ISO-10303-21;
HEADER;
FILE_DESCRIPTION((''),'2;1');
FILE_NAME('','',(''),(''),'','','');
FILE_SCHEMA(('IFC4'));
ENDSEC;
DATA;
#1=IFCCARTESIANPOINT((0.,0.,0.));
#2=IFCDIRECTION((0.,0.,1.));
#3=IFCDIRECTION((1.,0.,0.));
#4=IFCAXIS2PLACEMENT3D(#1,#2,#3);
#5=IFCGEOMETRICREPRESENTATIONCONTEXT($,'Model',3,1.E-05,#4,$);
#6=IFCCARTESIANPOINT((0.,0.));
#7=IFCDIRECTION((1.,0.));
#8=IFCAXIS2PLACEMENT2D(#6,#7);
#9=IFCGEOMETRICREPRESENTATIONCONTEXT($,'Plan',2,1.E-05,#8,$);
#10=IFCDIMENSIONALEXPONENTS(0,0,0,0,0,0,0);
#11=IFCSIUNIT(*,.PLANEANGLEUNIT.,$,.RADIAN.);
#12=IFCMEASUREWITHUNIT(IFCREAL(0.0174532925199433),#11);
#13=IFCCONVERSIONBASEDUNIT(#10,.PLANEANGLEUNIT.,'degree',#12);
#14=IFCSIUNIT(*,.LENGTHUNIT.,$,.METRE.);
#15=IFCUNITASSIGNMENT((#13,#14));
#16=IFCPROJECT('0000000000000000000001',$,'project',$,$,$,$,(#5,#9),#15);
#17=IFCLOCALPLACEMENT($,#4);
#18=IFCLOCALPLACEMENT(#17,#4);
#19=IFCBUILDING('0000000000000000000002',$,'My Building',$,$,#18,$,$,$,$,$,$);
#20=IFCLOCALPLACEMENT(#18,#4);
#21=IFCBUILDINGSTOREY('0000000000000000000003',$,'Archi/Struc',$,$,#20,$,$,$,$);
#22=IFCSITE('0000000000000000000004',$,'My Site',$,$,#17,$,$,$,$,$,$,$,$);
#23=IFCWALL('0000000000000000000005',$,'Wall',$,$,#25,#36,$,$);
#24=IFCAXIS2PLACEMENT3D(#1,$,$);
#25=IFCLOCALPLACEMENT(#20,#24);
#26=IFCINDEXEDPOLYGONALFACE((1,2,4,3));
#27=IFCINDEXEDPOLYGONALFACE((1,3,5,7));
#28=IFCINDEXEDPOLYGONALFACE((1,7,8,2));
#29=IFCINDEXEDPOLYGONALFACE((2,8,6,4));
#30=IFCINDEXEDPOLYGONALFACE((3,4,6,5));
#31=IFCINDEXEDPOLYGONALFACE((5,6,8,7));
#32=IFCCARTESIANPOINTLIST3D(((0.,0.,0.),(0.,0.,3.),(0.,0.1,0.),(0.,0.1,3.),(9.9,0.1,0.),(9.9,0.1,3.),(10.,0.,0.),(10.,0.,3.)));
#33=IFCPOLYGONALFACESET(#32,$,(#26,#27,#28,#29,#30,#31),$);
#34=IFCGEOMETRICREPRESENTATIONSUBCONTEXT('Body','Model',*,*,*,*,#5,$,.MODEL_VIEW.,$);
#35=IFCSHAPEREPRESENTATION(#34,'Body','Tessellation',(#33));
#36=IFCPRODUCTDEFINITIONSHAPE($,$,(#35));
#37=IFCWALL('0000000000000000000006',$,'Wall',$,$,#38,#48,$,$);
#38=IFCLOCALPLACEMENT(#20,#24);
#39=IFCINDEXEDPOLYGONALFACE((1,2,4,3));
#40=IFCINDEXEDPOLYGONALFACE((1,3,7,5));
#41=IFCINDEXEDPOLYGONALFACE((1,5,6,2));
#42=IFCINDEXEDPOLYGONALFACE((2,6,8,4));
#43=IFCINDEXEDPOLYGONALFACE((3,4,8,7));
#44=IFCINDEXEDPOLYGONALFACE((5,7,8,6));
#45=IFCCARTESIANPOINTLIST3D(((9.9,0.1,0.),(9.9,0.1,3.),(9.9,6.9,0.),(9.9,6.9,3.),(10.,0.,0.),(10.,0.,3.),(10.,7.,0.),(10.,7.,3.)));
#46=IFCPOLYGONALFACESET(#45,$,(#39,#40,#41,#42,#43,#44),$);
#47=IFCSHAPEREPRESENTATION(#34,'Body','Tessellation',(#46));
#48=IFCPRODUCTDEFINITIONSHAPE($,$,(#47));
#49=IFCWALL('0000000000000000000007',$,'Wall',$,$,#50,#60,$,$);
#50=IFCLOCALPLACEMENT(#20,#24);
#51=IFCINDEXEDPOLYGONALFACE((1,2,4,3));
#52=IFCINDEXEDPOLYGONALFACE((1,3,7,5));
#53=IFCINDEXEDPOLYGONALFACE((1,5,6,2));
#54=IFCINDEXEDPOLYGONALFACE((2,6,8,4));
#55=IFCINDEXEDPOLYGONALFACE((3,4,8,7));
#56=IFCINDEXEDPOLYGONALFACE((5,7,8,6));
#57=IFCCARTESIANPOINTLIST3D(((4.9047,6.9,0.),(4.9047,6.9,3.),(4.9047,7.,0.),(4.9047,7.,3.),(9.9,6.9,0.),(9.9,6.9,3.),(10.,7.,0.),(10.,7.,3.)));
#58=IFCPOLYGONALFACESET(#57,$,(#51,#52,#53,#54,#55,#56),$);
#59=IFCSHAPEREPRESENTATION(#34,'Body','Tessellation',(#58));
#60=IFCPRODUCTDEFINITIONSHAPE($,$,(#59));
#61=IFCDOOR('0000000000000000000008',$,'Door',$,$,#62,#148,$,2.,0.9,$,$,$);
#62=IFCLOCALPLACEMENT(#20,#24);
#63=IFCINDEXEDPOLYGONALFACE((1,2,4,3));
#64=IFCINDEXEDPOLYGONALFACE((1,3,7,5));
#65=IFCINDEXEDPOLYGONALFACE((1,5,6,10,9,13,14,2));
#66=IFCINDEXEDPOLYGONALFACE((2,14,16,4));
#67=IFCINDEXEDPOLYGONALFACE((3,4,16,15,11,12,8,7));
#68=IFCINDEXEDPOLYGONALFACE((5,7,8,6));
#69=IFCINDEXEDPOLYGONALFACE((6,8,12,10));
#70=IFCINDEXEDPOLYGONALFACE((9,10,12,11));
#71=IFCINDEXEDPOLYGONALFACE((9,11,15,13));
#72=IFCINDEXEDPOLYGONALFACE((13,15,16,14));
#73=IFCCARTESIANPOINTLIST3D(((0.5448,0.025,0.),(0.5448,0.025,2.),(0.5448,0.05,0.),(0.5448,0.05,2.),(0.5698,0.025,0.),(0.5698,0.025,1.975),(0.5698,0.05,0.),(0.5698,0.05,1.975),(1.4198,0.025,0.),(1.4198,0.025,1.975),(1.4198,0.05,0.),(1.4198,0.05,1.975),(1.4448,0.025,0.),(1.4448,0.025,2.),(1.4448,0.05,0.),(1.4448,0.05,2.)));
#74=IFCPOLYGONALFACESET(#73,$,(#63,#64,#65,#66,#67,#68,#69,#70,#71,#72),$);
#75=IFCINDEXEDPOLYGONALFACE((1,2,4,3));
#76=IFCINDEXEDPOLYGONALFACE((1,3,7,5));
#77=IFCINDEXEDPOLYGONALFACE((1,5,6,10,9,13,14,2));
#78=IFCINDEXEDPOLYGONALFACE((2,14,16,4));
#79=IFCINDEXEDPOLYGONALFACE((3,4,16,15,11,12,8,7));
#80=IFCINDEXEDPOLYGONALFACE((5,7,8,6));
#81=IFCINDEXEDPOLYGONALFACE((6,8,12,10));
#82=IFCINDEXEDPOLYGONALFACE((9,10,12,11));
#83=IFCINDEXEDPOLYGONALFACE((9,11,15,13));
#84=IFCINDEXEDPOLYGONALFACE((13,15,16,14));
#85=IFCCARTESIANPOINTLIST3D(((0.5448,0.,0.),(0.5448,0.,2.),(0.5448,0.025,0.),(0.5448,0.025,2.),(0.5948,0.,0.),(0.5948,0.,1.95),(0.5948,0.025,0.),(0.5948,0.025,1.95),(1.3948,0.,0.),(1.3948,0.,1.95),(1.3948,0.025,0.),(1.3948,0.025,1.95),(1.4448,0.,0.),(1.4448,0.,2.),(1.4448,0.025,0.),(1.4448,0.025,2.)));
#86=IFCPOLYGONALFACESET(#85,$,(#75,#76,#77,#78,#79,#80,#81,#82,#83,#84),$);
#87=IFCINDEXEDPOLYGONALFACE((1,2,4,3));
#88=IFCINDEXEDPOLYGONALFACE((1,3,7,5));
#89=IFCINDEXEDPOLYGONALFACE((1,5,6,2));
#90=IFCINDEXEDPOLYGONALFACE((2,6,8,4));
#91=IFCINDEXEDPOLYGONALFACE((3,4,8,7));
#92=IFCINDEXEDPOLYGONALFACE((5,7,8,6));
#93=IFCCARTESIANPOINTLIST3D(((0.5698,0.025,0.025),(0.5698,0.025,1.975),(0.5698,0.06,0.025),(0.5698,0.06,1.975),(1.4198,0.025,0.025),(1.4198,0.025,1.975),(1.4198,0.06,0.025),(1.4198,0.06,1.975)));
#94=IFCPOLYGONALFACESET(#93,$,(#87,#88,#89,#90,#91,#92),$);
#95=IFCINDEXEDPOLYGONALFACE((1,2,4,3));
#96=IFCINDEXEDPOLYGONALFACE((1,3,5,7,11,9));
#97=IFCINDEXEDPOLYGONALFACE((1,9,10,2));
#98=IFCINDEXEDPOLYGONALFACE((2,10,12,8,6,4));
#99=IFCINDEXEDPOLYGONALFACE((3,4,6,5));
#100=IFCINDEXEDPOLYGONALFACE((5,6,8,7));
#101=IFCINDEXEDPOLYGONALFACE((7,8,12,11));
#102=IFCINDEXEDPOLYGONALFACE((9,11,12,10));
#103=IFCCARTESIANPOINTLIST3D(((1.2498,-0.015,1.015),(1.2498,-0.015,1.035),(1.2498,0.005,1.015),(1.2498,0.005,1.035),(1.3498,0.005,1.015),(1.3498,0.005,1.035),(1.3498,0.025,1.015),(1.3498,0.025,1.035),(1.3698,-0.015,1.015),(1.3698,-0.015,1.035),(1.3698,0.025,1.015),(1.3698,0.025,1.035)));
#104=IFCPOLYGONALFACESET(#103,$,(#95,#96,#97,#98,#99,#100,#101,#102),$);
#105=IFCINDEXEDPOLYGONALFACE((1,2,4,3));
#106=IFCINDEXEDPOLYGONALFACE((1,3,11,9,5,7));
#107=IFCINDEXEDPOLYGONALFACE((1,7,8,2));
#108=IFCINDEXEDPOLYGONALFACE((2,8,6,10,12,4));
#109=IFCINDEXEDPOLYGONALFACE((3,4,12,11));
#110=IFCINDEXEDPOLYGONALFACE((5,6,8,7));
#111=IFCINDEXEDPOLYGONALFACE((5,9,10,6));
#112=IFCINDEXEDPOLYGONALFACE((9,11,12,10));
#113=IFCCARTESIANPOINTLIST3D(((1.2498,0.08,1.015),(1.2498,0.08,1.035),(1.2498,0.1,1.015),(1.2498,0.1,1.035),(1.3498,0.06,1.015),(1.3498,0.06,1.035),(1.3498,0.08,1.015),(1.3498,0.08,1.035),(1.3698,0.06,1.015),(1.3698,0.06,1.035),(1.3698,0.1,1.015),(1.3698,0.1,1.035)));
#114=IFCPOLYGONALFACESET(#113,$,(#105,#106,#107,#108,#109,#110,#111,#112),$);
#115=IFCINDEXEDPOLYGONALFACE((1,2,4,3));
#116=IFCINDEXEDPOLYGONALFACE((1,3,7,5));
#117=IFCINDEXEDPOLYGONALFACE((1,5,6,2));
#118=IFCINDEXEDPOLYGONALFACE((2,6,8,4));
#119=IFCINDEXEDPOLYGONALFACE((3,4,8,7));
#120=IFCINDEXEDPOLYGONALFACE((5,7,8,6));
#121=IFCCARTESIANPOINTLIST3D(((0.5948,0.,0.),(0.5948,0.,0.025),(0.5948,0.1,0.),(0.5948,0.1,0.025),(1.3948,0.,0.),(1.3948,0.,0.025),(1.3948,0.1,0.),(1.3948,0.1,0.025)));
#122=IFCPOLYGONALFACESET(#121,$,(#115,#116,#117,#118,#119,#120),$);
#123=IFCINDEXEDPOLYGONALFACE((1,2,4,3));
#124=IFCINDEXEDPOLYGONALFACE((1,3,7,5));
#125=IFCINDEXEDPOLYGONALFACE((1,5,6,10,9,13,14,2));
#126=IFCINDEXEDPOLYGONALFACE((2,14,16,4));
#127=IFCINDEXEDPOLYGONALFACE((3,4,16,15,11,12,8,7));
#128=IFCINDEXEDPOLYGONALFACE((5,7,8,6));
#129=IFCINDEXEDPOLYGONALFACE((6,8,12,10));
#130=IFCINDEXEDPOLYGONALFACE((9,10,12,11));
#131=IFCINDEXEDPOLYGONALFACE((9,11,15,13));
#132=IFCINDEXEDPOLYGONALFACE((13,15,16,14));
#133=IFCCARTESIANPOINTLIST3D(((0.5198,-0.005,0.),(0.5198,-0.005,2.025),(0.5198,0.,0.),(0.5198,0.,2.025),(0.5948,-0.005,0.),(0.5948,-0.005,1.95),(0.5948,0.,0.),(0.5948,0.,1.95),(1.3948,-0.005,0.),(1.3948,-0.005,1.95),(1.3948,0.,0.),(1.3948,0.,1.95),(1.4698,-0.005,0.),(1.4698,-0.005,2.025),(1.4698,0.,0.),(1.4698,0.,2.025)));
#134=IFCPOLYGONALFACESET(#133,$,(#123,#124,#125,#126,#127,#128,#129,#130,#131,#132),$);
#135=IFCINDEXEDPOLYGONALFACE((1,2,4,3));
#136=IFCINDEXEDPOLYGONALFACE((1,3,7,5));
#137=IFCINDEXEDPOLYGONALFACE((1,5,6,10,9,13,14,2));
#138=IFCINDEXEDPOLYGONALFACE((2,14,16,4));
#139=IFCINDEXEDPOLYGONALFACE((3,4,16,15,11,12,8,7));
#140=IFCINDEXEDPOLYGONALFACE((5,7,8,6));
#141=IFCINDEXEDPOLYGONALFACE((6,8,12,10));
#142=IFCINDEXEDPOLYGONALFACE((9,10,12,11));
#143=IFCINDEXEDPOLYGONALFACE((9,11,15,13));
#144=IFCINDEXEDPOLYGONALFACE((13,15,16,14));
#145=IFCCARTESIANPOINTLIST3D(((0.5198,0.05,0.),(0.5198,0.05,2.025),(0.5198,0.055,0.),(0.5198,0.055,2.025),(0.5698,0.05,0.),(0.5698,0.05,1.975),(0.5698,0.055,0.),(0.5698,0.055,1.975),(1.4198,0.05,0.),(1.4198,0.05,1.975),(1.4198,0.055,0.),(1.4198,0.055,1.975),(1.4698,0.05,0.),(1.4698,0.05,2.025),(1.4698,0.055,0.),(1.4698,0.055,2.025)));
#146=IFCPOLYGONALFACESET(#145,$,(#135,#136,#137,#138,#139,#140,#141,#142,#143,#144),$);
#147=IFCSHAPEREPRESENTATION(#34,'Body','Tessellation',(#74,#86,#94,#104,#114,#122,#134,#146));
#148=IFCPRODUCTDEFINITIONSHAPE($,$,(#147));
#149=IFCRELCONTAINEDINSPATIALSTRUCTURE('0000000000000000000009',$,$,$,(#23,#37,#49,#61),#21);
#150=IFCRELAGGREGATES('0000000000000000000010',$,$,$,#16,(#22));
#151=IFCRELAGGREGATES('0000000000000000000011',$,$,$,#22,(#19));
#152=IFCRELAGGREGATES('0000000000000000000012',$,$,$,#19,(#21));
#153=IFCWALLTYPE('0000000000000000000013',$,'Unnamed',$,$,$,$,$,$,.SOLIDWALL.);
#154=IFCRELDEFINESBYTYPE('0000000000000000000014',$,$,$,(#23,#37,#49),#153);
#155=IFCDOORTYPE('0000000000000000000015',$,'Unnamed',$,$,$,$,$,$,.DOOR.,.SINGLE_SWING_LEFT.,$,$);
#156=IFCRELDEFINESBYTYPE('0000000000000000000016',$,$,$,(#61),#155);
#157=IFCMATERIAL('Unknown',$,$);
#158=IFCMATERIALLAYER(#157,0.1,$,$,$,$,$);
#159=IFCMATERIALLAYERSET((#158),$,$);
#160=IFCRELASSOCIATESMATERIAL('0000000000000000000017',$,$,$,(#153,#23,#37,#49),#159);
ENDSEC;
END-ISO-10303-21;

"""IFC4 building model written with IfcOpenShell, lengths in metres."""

from ifc_helpers import new_model, entity, si_unit, converted_unit, frame, origin_with_axes, origin_2d_with_axis, place, context, subcontext, project, spatial, line, indexed_curve, outline, extrude, shape, source, transform, mapped, material, layer, layer_set, layer_usage, type_object, type_shapes, element, save


model = new_model("IFC4")

# Units and contexts
model_context = context("Model", 3, precision=1e-05, world=origin_with_axes())
plan_context = context("Plan", 2, precision=1e-05, world=origin_2d_with_axis())
body_context_1 = subcontext(model_context, "Body", "Model", "MODEL_VIEW")
body_context_2 = subcontext(plan_context, "Body", "Plan", "PLAN_VIEW")
ifc_project = project(units=[converted_unit("PLANEANGLEUNIT", "degree", entity("IfcReal", 0.0174532925199433), si_unit("PLANEANGLEUNIT", "RADIAN"), dimensions=[0, 0, 0, 0, 0, 0, 0]), si_unit("LENGTHUNIT", "METRE")], contexts=[model_context, plan_context])

# Site, building, storey
site_placement = place(None, origin_with_axes())
site = spatial("IfcSite", under=ifc_project, at=site_placement, Name="My Site")
building_placement = place(site_placement, origin_with_axes())
building = spatial("IfcBuilding", under=site, at=building_placement, Name="My Building")
storey_placement = place(building_placement, origin_with_axes())
storey = spatial("IfcBuildingStorey", under=building, at=storey_placement, Name="Archi/Struc")

# Shared definitions
ifc_material = material(Name="Unknown")

# Shared definitions
ifc_layer_1 = layer(ifc_material, 0.1)
ifc_layer_set_1 = layer_set([ifc_layer_1])
wall_type = type_object("IfcWallType", Name="Unnamed", PredefinedType="SOLIDWALL", material=ifc_layer_set_1)

# Shared definitions
door_type = type_object("IfcDoorType", Name="Unnamed", OperationType="SINGLE_SWING_LEFT", PredefinedType="DOOR")
shared_shape_1 = source(origin_with_axes(), body_context_1, "Body", "SweptSolid", [
    extrude(outline(indexed_curve([(0.0, 0.0), (0.0, 2.0), (0.9, 2.0), (0.9, 0.0), (0.875, 0.0), (0.875, 1.975), (0.025, 1.975), (0.025, 0.0)], segments=[line(1, 2, 3, 4, 5, 6, 7, 8, 1)])), frame((0.0, 0.025, 0.0), z_axis=(0.0, -1.0, 0.0), x_axis=(1.0, 0.0, 0.0)), (0.0, 0.0, -1.0), 0.025),
    extrude(outline(indexed_curve([(0.0, 0.0), (0.0, 2.0), (0.9, 2.0), (0.9, 0.0), (0.85, 0.0), (0.85, 1.95), (0.05, 1.95), (0.05, 0.0)], segments=[line(1, 2, 3, 4, 5, 6, 7, 8, 1)])), frame((0.0, 0.0, 0.0), z_axis=(0.0, -1.0, 0.0), x_axis=(1.0, 0.0, 0.0)), (0.0, 0.0, -1.0), 0.025),
    extrude(outline(indexed_curve([(0.0, 0.0), (0.85, 0.0), (0.85, 0.035), (0.0, 0.035)], segments=[line(1, 2, 3, 4, 1)])), frame((0.025, 0.025, 0.025), z_axis=(0.0, 0.0, 1.0), x_axis=(1.0, 0.0, 0.0)), (0.0, 0.0, 1.0), 1.95),
    extrude(outline(indexed_curve([(0.0, 0.0), (0.0, -0.04), (-0.12, -0.04), (-0.12, -0.02), (-0.02, -0.02), (-0.02, 0.0)], segments=[line(1, 2, 3, 4, 5, 6, 1)])), frame((0.825, 0.025, 1.015), z_axis=(0.0, 0.0, 1.0), x_axis=(1.0, 0.0, 0.0)), (0.0, 0.0, 1.0), 0.02),
    extrude(outline(indexed_curve([(0.0, 0.0), (0.0, 0.04), (-0.12, 0.04), (-0.12, 0.02), (-0.02, 0.02), (-0.02, 0.0)], segments=[line(1, 2, 3, 4, 5, 6, 1)])), frame((0.825, 0.06, 1.015), z_axis=(0.0, 0.0, 1.0), x_axis=(1.0, 0.0, 0.0)), (0.0, 0.0, 1.0), 0.02),
    extrude(outline(indexed_curve([(0.0, 0.0), (0.8, 0.0), (0.8, 0.1), (0.0, 0.1)], segments=[line(1, 2, 3, 4, 1)])), frame((0.05, 0.0, 0.0), z_axis=(0.0, 0.0, 1.0), x_axis=(1.0, 0.0, 0.0)), (0.0, 0.0, 1.0), 0.025),
    extrude(outline(indexed_curve([(0.0, 0.0), (0.0, 2.025), (0.95, 2.025), (0.95, 0.0), (0.875, 0.0), (0.875, 1.95), (0.075, 1.95), (0.075, 0.0)], segments=[line(1, 2, 3, 4, 5, 6, 7, 8, 1)])), frame((-0.025, -0.005, 0.0), z_axis=(0.0, -1.0, 0.0), x_axis=(1.0, 0.0, 0.0)), (0.0, 0.0, -1.0), 0.005),
    extrude(outline(indexed_curve([(0.0, 0.0), (0.0, 2.025), (0.95, 2.025), (0.95, 0.0), (0.9, 0.0), (0.9, 1.975), (0.05, 1.975), (0.05, 0.0)], segments=[line(1, 2, 3, 4, 5, 6, 7, 8, 1)])), frame((-0.025, 0.05, 0.0), z_axis=(0.0, -1.0, 0.0), x_axis=(1.0, 0.0, 0.0)), (0.0, 0.0, -1.0), 0.005),
])
shared_shape_2 = source(origin_with_axes(), body_context_2, "Body", "Curve2D", [
    entity("IfcIndexedPolyCurve", entity("IfcCartesianPointList2D", [[0.0, 0.0], [0.0, 0.05], [0.025, 0.05], [0.025, 0.025], [0.05, 0.025], [0.05, 0.0]]), [entity("IfcLineIndex", [1, 2, 3, 4, 5, 6, 1])]),
    entity("IfcIndexedPolyCurve", entity("IfcCartesianPointList2D", [[0.9, 0.0], [0.9, 0.05], [0.875, 0.05], [0.875, 0.025], [0.85, 0.025], [0.85, 0.0]]), [entity("IfcLineIndex", [1, 2, 3, 4, 5, 6, 1])]),
    entity("IfcTrimmedCurve", entity("IfcEllipse", entity("IfcAxis2Placement2D", entity("IfcCartesianPoint", [0.06, 0.05]), entity("IfcDirection", [1.0, 0.0])), 0.815, 0.85), [entity("IfcCartesianPoint", [0.875, 0.05])], [entity("IfcCartesianPoint", [0.06, 0.9])], True, "CARTESIAN"),
    entity("IfcIndexedPolyCurve", entity("IfcCartesianPointList2D", [[0.025, 0.05], [0.06, 0.05], [0.06, 0.9], [0.025, 0.9]]), [entity("IfcLineIndex", [1, 2, 3, 4, 1])]),
])
type_shapes(door_type, [shared_shape_1, shared_shape_2])

# Walls
ifc_layer_usage_1 = layer_usage(ifc_layer_set_1, "AXIS2", "POSITIVE", 0.0)
wall_1_placement = place(storey_placement, origin_with_axes())
element("IfcWall", 1, at=wall_1_placement, inside=storey, type_object=wall_type, material=ifc_layer_usage_1, Name="Wall", context=body_context_1, shape_type="SweptSolid", body=[
    extrude(outline(indexed_curve([(0.0, 0.0), (0.0, 0.1), (9.9, 0.1), (10.0, 0.0)], segments=[line(1, 2, 3, 4, 1)])), origin_with_axes(), (0.0, 0.0, 1.0), 3.0),
])
ifc_layer_usage_2 = layer_usage(ifc_layer_set_1, "AXIS2", "POSITIVE", 0.0)
wall_2_placement = place(storey_placement, frame((10.0, 0.0, 0.0), z_axis=(0.0, 0.0, 1.0), x_axis=(0.0, 1.0, 0.0)))
element("IfcWall", 2, at=wall_2_placement, inside=storey, type_object=wall_type, material=ifc_layer_usage_2, Name="Wall", context=body_context_1, shape_type="SweptSolid", body=[
    extrude(outline(indexed_curve([(0.0, 0.0), (0.1, 0.1), (6.9, 0.1), (7.0, 0.0)], segments=[line(1, 2, 3, 4, 1)])), origin_with_axes(), (0.0, 0.0, 1.0), 3.0),
])
ifc_layer_usage_3 = layer_usage(ifc_layer_set_1, "AXIS2", "POSITIVE", 0.0)
wall_3_placement = place(storey_placement, frame((10.0, 7.0, 0.0), z_axis=(0.0, 0.0, 1.0), x_axis=(-1.0, 0.0, 0.0)))
element("IfcWall", 3, at=wall_3_placement, inside=storey, type_object=wall_type, material=ifc_layer_usage_3, Name="Wall", context=body_context_1, shape_type="SweptSolid", body=[
    extrude(outline(indexed_curve([(0.0, 0.0), (0.1, 0.1), (5.0953, 0.1), (5.0953, 0.0)], segments=[line(1, 2, 3, 4, 1)])), origin_with_axes(), (0.0, 0.0, 1.0), 3.0),
])

# Door
placement_1 = place(storey_placement, frame((0.0, 0.0, 0.0), z_axis=(0.0, 0.0, 1.0), x_axis=(1.0, 0.0, 0.0)))
placement_2 = place(placement_1, frame((0.5448, 0.0, 0.0), z_axis=(0.0, 0.0, 1.0), x_axis=(1.0, 0.0, 0.0)))
door_1_placement = place(placement_2, origin_with_axes())
element("IfcDoor", 4, at=door_1_placement, inside=storey, type_object=door_type, Name="Door", OverallHeight=2.0, OverallWidth=0.9, shapes=[
    shape(body_context_1, "Body", "MappedRepresentation", [mapped(shared_shape_1, transform((0.0, 0.0, 0.0), x_axis=(1.0, 0.0, 0.0), y_axis=(0.0, 1.0, 0.0), z_axis=(0.0, 0.0, 1.0), scale=1.0))]),
    shape(body_context_2, "Body", "MappedRepresentation", [mapped(shared_shape_2, transform((0.0, 0.0, 0.0), x_axis=(1.0, 0.0, 0.0), y_axis=(0.0, 1.0, 0.0), z_axis=(0.0, 0.0, 1.0), scale=1.0))]),
])

save(model, "model.ifc")
